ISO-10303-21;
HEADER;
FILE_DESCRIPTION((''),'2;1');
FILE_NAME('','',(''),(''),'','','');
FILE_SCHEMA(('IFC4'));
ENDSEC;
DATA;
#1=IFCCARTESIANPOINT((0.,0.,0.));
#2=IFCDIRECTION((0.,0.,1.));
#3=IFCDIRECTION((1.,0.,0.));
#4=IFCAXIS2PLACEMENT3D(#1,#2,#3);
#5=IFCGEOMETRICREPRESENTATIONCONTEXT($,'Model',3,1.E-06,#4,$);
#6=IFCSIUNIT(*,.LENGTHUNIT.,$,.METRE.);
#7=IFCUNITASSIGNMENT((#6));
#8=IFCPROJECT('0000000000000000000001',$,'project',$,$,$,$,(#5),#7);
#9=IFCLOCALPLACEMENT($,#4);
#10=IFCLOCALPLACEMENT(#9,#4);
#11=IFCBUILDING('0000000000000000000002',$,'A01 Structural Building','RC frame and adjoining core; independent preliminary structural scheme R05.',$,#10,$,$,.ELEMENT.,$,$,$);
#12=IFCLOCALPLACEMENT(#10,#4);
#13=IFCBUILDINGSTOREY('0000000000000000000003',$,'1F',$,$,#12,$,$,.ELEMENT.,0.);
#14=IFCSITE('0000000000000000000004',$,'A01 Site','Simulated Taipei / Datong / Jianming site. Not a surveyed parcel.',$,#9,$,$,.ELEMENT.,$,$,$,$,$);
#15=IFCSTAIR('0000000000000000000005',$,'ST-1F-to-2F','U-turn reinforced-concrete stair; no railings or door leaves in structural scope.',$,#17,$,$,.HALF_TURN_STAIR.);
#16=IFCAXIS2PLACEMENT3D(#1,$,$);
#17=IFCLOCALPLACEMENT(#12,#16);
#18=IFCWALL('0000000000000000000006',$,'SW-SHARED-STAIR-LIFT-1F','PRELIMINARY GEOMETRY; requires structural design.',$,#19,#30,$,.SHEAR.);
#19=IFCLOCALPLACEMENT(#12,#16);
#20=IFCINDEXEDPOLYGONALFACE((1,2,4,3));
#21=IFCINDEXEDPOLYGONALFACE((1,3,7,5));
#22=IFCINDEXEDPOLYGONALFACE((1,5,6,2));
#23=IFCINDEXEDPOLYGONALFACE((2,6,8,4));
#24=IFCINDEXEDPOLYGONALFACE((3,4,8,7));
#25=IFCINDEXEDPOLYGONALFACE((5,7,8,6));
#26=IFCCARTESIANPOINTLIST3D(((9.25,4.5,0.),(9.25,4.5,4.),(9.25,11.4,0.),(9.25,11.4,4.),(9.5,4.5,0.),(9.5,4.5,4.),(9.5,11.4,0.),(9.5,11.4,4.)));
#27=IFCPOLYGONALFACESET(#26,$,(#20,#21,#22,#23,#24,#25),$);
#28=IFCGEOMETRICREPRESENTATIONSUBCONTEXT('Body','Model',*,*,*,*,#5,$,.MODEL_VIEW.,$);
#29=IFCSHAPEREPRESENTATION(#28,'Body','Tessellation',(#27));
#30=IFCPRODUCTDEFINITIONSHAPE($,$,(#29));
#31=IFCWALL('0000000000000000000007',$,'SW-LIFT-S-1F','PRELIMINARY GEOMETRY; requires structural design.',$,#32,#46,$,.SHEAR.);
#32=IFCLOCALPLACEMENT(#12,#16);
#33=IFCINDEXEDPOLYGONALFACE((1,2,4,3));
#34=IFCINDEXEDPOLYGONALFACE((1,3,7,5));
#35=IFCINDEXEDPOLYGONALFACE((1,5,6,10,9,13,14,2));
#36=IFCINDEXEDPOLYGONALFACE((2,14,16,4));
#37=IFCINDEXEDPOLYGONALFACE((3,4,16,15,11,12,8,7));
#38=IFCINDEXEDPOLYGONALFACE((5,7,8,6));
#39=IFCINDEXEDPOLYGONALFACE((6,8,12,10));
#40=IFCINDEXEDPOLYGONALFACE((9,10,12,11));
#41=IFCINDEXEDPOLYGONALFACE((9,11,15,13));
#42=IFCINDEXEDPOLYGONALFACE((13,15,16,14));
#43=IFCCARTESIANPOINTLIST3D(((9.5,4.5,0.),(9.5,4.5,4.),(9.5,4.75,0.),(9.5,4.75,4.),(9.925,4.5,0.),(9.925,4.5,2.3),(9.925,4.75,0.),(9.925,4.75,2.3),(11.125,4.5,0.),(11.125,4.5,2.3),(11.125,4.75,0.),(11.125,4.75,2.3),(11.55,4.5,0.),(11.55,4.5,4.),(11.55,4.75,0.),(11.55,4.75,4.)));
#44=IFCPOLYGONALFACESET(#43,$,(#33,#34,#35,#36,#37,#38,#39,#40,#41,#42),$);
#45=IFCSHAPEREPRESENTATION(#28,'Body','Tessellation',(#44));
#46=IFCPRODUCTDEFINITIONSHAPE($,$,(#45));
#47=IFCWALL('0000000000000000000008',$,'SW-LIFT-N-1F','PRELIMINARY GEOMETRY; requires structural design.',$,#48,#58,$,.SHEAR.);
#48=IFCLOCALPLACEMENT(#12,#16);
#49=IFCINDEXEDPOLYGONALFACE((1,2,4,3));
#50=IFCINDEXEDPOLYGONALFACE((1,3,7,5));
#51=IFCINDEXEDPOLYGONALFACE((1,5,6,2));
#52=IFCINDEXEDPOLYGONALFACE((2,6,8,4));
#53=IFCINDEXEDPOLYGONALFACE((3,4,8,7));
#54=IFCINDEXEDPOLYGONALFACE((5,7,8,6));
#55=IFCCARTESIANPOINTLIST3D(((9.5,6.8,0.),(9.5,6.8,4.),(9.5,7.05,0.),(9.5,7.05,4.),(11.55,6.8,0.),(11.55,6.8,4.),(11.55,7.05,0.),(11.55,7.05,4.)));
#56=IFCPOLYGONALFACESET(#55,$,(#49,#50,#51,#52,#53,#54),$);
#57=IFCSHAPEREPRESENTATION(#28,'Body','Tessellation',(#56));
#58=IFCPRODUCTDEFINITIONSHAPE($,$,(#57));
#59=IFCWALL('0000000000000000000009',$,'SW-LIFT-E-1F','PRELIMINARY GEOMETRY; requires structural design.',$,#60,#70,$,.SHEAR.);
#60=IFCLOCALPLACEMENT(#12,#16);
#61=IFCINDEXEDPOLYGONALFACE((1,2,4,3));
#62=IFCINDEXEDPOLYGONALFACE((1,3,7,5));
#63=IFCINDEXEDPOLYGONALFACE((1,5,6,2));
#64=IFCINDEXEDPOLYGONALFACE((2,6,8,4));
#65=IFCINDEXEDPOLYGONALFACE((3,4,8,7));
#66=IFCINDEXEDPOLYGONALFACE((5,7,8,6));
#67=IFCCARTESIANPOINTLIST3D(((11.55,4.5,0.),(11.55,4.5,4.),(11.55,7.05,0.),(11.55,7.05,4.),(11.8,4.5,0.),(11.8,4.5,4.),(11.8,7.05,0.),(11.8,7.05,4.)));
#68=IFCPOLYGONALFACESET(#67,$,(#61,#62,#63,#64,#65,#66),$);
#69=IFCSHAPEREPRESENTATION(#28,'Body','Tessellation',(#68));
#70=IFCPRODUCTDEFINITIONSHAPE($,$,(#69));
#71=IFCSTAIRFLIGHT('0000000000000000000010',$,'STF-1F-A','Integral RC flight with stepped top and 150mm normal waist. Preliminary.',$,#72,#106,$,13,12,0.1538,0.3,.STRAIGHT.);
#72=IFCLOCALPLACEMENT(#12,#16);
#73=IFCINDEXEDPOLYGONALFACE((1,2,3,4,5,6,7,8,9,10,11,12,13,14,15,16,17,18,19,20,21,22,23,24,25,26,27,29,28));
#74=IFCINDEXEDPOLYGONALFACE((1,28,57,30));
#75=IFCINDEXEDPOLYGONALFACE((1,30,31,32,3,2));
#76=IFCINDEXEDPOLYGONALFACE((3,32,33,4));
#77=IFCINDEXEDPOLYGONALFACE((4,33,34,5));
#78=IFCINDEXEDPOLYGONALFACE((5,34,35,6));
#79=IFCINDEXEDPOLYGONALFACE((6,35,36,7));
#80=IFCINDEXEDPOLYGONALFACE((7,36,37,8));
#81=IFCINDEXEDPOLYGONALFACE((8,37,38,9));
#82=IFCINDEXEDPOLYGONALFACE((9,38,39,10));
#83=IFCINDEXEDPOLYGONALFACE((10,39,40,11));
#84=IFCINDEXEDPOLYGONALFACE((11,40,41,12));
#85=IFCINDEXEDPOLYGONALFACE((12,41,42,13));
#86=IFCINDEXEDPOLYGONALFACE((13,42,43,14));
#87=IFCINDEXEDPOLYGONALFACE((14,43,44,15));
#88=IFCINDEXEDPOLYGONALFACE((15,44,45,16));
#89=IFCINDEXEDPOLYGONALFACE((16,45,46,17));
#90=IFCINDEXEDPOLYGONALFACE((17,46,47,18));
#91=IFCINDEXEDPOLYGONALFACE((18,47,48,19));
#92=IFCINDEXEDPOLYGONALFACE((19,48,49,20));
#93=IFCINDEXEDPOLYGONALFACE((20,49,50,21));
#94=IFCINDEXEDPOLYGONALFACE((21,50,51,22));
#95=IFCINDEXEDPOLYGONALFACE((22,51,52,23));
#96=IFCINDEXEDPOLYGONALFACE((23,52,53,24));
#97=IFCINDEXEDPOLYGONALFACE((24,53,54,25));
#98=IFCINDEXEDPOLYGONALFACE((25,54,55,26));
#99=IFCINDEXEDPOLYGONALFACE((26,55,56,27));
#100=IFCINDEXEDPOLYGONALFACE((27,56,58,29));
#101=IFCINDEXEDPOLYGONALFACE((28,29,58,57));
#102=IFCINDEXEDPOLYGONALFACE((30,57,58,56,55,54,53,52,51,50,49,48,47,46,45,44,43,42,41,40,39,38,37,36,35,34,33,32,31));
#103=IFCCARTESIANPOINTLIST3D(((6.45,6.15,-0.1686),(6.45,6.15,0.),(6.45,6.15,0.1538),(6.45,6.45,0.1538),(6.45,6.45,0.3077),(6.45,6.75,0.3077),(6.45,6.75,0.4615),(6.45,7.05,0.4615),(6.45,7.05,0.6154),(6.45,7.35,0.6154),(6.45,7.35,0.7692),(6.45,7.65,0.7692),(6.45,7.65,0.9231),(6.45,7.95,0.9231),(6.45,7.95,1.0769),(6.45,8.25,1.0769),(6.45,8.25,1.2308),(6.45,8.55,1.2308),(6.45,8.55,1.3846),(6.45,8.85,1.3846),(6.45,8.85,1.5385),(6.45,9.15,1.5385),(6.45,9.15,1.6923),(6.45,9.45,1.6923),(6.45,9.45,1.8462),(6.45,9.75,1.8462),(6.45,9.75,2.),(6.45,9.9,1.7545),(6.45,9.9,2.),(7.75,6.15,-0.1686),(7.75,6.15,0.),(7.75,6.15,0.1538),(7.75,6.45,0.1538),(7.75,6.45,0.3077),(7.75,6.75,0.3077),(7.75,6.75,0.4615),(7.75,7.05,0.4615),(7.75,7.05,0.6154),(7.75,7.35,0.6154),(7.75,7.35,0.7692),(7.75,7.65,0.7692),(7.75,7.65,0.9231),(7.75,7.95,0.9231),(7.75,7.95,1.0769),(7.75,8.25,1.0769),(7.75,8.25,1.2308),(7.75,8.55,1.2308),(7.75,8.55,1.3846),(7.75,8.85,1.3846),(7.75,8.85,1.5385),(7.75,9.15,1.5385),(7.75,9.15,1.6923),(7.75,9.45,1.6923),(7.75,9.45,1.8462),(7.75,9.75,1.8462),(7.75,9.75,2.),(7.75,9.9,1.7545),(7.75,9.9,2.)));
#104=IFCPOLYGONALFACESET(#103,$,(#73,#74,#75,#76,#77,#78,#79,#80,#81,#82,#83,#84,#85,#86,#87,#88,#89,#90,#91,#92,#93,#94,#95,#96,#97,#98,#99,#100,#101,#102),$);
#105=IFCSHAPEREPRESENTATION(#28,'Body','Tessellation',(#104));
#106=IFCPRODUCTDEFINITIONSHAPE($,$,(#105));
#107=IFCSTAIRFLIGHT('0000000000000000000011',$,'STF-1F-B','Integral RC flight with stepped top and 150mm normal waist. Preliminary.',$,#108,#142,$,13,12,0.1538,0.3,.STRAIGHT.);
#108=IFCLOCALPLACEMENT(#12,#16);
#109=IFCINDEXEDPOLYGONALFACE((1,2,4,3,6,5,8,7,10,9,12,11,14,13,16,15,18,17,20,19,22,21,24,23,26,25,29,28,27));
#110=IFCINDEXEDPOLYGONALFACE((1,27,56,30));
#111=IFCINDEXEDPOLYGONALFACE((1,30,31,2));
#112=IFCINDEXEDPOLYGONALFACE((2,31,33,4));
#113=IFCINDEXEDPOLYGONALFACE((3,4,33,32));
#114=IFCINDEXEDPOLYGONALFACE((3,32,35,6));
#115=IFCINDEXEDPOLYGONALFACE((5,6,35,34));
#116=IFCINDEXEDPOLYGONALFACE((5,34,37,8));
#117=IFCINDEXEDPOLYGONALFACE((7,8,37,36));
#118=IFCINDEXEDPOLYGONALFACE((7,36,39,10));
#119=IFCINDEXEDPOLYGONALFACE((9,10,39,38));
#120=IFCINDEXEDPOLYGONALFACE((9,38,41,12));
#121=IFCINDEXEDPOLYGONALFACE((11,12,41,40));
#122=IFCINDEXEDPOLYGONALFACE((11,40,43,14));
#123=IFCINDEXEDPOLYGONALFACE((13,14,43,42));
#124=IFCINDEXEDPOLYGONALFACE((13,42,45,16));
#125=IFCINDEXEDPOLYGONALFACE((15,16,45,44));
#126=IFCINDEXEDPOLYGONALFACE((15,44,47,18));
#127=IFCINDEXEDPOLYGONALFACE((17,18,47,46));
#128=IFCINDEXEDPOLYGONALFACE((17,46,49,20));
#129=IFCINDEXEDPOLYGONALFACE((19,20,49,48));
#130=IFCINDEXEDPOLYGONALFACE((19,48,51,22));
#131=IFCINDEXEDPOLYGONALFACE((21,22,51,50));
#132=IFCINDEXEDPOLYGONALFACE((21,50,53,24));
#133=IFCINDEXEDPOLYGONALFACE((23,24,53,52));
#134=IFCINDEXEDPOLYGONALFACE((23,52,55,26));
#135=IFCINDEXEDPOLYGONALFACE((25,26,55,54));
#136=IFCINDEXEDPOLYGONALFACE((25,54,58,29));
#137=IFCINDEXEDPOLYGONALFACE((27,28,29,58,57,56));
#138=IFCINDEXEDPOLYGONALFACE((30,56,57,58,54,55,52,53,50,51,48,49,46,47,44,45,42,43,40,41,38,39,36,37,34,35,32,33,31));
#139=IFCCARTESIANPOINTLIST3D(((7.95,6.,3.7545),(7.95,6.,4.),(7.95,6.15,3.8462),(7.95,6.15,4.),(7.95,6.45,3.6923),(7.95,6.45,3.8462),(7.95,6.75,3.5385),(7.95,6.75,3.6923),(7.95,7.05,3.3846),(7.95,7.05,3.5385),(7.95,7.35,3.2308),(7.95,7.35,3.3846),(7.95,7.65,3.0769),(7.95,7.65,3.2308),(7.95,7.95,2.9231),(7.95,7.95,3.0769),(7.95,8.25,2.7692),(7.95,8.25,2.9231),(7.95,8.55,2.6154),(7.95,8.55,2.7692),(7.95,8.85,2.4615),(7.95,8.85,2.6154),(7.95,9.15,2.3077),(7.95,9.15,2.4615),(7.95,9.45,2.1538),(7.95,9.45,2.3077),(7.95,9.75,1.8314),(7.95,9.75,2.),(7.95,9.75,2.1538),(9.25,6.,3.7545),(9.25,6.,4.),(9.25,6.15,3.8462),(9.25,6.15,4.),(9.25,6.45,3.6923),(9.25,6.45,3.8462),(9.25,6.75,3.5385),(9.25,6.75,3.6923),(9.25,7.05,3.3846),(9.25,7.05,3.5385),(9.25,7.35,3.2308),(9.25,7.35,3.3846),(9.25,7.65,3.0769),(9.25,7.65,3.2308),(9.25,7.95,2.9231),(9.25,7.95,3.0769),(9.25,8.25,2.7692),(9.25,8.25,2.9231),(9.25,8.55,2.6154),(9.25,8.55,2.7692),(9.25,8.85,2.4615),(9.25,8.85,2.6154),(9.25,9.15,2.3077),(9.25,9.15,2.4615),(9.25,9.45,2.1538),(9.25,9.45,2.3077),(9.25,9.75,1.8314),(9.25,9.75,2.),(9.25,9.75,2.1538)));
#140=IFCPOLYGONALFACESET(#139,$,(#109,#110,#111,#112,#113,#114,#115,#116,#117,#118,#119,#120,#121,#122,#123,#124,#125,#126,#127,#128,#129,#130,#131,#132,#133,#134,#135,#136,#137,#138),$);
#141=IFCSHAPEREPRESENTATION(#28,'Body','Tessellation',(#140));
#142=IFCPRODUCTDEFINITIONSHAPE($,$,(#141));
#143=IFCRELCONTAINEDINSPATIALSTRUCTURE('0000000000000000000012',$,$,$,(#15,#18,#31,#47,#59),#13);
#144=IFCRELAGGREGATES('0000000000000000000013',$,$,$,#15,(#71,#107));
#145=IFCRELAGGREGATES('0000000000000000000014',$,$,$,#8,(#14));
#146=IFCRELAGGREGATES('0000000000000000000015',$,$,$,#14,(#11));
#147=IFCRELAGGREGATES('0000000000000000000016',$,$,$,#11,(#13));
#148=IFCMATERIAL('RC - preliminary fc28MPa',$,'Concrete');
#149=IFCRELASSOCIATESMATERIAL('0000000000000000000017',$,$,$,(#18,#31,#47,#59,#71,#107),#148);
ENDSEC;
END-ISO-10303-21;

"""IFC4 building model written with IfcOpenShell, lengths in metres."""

from ifc_helpers import new_model, si_unit, frame, origin_with_axes, place, context, subcontext, project, spatial, polyline, rectangle, outline, extrude, material, element, aggregate, save


model = new_model("IFC4")

# Units and contexts
model_context = context("Model", 3, precision=1e-06, world=origin_with_axes())
body_context = subcontext(model_context, "Body", "Model", "MODEL_VIEW")
ifc_project = project(units=[si_unit("LENGTHUNIT", "METRE")], contexts=[model_context])

# Site, building, storey
site_placement = place(None, origin_with_axes())
site = spatial("IfcSite", under=ifc_project, at=site_placement, Name="A01 Site", Description="Simulated Taipei / Datong / Jianming site. Not a surveyed parcel.", CompositionType="ELEMENT")
building_placement = place(site_placement, origin_with_axes())
building = spatial("IfcBuilding", under=site, at=building_placement, Name="A01 Structural Building", Description="RC frame and adjoining core; independent preliminary structural scheme R05.", CompositionType="ELEMENT")
storey_placement = place(building_placement, origin_with_axes())
storey = spatial("IfcBuildingStorey", under=building, at=storey_placement, Name="1F", CompositionType="ELEMENT", Elevation=0.0)

# Shared definitions
ifc_material = material(Name="RC - preliminary fc28MPa", Category="Concrete")

# Stair
stair_placement = place(storey_placement, origin_with_axes())
stair = element("IfcStair", 1, at=stair_placement, inside=storey, Name="ST-1F-to-2F", Description="U-turn reinforced-concrete stair; no railings or door leaves in structural scope.", PredefinedType="HALF_TURN_STAIR")

# Wall
wall_1_placement = place(storey_placement, frame((9.375, 7.95, 0.0), z_axis=(0.0, 0.0, 1.0), x_axis=(1.0, 0.0, 0.0)))
element("IfcWall", 2, at=wall_1_placement, inside=storey, material=ifc_material, Name="SW-SHARED-STAIR-LIFT-1F", Description="PRELIMINARY GEOMETRY; requires structural design.", PredefinedType="SHEAR", context=body_context, shape_type="SweptSolid", body=[
    extrude(rectangle(XDim=0.25, YDim=6.9), origin_with_axes(), (0.0, 0.0, 1.0), 4.0),
])

# Wall, opening
wall_2_placement = place(storey_placement, frame((10.525, 4.625, 0.0), z_axis=(0.0, 0.0, 1.0), x_axis=(1.0, 0.0, 0.0)))
wall_2 = element("IfcWall", 3, at=wall_2_placement, inside=storey, material=ifc_material, Name="SW-LIFT-S-1F", Description="PRELIMINARY GEOMETRY; requires structural design.", PredefinedType="SHEAR", context=body_context, shape_type="SweptSolid", body=[
    extrude(rectangle(XDim=2.05, YDim=0.25), origin_with_axes(), (0.0, 0.0, 1.0), 4.0),
])
opening_1_placement = place(storey_placement, frame((10.525, 4.625, 0.0), z_axis=(0.0, 0.0, 1.0), x_axis=(1.0, 0.0, 0.0)))
element("IfcOpeningElement", 4, at=opening_1_placement, cuts=wall_2, PredefinedType="OPENING", context=body_context, shape_type="SweptSolid", body=[
    extrude(rectangle(XDim=1.2, YDim=0.45), origin_with_axes(), (0.0, 0.0, 1.0), 2.3),
])

# Walls
wall_3_placement = place(storey_placement, frame((10.525, 6.925, 0.0), z_axis=(0.0, 0.0, 1.0), x_axis=(1.0, 0.0, 0.0)))
element("IfcWall", 5, at=wall_3_placement, inside=storey, material=ifc_material, Name="SW-LIFT-N-1F", Description="PRELIMINARY GEOMETRY; requires structural design.", PredefinedType="SHEAR", context=body_context, shape_type="SweptSolid", body=[
    extrude(rectangle(XDim=2.05, YDim=0.25), origin_with_axes(), (0.0, 0.0, 1.0), 4.0),
])
wall_4_placement = place(storey_placement, frame((11.675, 5.775, 0.0), z_axis=(0.0, 0.0, 1.0), x_axis=(1.0, 0.0, 0.0)))
element("IfcWall", 6, at=wall_4_placement, inside=storey, material=ifc_material, Name="SW-LIFT-E-1F", Description="PRELIMINARY GEOMETRY; requires structural design.", PredefinedType="SHEAR", context=body_context, shape_type="SweptSolid", body=[
    extrude(rectangle(XDim=0.25, YDim=2.55), origin_with_axes(), (0.0, 0.0, 1.0), 4.0),
])

# Stair flights
stair_flight_1_placement = place(storey_placement, origin_with_axes())
stair_flight_1 = element("IfcStairFlight", 7, at=stair_flight_1_placement, material=ifc_material, Name="STF-1F-A", Description="Integral RC flight with stepped top and 150mm normal waist. Preliminary.", NumberOfRisers=13, NumberOfTreads=12, PredefinedType="STRAIGHT", RiserHeight=0.1538, TreadLength=0.3, context=body_context, shape_type="SweptSolid", body=[
    extrude(outline(polyline([(0.0, 0.0), (0.0, 0.1538), (0.3, 0.1538), (0.3, 0.3077), (0.6, 0.3077), (0.6, 0.4615), (0.9, 0.4615), (0.9, 0.6154), (1.2, 0.6154), (1.2, 0.7692), (1.5, 0.7692), (1.5, 0.9231), (1.8, 0.9231), (1.8, 1.0769), (2.1, 1.0769), (2.1, 1.2308), (2.4, 1.2308), (2.4, 1.3846), (2.7, 1.3846), (2.7, 1.5385), (3.0, 1.5385), (3.0, 1.6923), (3.3, 1.6923), (3.3, 1.8462), (3.6, 1.8462), (3.6, 2.0), (3.75, 2.0), (3.75, 1.7545), (0.0, -0.1686), (0.0, 0.0)])), frame((6.45, 6.15, 0.0), z_axis=(1.0, 0.0, 0.0), x_axis=(0.0, 1.0, 0.0)), (0.0, 0.0, 1.0), 1.3),
])
stair_flight_2_placement = place(storey_placement, origin_with_axes())
stair_flight_2 = element("IfcStairFlight", 8, at=stair_flight_2_placement, material=ifc_material, Name="STF-1F-B", Description="Integral RC flight with stepped top and 150mm normal waist. Preliminary.", NumberOfRisers=13, NumberOfTreads=12, PredefinedType="STRAIGHT", RiserHeight=0.1538, TreadLength=0.3, context=body_context, shape_type="SweptSolid", body=[
    extrude(outline(polyline([(0.0, 0.0), (0.0, 0.1538), (0.3, 0.1538), (0.3, 0.3077), (0.6, 0.3077), (0.6, 0.4615), (0.9, 0.4615), (0.9, 0.6154), (1.2, 0.6154), (1.2, 0.7692), (1.5, 0.7692), (1.5, 0.9231), (1.8, 0.9231), (1.8, 1.0769), (2.1, 1.0769), (2.1, 1.2308), (2.4, 1.2308), (2.4, 1.3846), (2.7, 1.3846), (2.7, 1.5385), (3.0, 1.5385), (3.0, 1.6923), (3.3, 1.6923), (3.3, 1.8462), (3.6, 1.8462), (3.6, 2.0), (3.75, 2.0), (3.75, 1.7545), (0.0, -0.1686), (0.0, 0.0)])), frame((9.25, 9.75, 2.0), z_axis=(-1.0, 0.0, 0.0), x_axis=(0.0, -1.0, 0.0)), (0.0, 0.0, 1.0), 1.3),
])
aggregate(stair, [stair_flight_1, stair_flight_2])

save(model, "model.ifc")
